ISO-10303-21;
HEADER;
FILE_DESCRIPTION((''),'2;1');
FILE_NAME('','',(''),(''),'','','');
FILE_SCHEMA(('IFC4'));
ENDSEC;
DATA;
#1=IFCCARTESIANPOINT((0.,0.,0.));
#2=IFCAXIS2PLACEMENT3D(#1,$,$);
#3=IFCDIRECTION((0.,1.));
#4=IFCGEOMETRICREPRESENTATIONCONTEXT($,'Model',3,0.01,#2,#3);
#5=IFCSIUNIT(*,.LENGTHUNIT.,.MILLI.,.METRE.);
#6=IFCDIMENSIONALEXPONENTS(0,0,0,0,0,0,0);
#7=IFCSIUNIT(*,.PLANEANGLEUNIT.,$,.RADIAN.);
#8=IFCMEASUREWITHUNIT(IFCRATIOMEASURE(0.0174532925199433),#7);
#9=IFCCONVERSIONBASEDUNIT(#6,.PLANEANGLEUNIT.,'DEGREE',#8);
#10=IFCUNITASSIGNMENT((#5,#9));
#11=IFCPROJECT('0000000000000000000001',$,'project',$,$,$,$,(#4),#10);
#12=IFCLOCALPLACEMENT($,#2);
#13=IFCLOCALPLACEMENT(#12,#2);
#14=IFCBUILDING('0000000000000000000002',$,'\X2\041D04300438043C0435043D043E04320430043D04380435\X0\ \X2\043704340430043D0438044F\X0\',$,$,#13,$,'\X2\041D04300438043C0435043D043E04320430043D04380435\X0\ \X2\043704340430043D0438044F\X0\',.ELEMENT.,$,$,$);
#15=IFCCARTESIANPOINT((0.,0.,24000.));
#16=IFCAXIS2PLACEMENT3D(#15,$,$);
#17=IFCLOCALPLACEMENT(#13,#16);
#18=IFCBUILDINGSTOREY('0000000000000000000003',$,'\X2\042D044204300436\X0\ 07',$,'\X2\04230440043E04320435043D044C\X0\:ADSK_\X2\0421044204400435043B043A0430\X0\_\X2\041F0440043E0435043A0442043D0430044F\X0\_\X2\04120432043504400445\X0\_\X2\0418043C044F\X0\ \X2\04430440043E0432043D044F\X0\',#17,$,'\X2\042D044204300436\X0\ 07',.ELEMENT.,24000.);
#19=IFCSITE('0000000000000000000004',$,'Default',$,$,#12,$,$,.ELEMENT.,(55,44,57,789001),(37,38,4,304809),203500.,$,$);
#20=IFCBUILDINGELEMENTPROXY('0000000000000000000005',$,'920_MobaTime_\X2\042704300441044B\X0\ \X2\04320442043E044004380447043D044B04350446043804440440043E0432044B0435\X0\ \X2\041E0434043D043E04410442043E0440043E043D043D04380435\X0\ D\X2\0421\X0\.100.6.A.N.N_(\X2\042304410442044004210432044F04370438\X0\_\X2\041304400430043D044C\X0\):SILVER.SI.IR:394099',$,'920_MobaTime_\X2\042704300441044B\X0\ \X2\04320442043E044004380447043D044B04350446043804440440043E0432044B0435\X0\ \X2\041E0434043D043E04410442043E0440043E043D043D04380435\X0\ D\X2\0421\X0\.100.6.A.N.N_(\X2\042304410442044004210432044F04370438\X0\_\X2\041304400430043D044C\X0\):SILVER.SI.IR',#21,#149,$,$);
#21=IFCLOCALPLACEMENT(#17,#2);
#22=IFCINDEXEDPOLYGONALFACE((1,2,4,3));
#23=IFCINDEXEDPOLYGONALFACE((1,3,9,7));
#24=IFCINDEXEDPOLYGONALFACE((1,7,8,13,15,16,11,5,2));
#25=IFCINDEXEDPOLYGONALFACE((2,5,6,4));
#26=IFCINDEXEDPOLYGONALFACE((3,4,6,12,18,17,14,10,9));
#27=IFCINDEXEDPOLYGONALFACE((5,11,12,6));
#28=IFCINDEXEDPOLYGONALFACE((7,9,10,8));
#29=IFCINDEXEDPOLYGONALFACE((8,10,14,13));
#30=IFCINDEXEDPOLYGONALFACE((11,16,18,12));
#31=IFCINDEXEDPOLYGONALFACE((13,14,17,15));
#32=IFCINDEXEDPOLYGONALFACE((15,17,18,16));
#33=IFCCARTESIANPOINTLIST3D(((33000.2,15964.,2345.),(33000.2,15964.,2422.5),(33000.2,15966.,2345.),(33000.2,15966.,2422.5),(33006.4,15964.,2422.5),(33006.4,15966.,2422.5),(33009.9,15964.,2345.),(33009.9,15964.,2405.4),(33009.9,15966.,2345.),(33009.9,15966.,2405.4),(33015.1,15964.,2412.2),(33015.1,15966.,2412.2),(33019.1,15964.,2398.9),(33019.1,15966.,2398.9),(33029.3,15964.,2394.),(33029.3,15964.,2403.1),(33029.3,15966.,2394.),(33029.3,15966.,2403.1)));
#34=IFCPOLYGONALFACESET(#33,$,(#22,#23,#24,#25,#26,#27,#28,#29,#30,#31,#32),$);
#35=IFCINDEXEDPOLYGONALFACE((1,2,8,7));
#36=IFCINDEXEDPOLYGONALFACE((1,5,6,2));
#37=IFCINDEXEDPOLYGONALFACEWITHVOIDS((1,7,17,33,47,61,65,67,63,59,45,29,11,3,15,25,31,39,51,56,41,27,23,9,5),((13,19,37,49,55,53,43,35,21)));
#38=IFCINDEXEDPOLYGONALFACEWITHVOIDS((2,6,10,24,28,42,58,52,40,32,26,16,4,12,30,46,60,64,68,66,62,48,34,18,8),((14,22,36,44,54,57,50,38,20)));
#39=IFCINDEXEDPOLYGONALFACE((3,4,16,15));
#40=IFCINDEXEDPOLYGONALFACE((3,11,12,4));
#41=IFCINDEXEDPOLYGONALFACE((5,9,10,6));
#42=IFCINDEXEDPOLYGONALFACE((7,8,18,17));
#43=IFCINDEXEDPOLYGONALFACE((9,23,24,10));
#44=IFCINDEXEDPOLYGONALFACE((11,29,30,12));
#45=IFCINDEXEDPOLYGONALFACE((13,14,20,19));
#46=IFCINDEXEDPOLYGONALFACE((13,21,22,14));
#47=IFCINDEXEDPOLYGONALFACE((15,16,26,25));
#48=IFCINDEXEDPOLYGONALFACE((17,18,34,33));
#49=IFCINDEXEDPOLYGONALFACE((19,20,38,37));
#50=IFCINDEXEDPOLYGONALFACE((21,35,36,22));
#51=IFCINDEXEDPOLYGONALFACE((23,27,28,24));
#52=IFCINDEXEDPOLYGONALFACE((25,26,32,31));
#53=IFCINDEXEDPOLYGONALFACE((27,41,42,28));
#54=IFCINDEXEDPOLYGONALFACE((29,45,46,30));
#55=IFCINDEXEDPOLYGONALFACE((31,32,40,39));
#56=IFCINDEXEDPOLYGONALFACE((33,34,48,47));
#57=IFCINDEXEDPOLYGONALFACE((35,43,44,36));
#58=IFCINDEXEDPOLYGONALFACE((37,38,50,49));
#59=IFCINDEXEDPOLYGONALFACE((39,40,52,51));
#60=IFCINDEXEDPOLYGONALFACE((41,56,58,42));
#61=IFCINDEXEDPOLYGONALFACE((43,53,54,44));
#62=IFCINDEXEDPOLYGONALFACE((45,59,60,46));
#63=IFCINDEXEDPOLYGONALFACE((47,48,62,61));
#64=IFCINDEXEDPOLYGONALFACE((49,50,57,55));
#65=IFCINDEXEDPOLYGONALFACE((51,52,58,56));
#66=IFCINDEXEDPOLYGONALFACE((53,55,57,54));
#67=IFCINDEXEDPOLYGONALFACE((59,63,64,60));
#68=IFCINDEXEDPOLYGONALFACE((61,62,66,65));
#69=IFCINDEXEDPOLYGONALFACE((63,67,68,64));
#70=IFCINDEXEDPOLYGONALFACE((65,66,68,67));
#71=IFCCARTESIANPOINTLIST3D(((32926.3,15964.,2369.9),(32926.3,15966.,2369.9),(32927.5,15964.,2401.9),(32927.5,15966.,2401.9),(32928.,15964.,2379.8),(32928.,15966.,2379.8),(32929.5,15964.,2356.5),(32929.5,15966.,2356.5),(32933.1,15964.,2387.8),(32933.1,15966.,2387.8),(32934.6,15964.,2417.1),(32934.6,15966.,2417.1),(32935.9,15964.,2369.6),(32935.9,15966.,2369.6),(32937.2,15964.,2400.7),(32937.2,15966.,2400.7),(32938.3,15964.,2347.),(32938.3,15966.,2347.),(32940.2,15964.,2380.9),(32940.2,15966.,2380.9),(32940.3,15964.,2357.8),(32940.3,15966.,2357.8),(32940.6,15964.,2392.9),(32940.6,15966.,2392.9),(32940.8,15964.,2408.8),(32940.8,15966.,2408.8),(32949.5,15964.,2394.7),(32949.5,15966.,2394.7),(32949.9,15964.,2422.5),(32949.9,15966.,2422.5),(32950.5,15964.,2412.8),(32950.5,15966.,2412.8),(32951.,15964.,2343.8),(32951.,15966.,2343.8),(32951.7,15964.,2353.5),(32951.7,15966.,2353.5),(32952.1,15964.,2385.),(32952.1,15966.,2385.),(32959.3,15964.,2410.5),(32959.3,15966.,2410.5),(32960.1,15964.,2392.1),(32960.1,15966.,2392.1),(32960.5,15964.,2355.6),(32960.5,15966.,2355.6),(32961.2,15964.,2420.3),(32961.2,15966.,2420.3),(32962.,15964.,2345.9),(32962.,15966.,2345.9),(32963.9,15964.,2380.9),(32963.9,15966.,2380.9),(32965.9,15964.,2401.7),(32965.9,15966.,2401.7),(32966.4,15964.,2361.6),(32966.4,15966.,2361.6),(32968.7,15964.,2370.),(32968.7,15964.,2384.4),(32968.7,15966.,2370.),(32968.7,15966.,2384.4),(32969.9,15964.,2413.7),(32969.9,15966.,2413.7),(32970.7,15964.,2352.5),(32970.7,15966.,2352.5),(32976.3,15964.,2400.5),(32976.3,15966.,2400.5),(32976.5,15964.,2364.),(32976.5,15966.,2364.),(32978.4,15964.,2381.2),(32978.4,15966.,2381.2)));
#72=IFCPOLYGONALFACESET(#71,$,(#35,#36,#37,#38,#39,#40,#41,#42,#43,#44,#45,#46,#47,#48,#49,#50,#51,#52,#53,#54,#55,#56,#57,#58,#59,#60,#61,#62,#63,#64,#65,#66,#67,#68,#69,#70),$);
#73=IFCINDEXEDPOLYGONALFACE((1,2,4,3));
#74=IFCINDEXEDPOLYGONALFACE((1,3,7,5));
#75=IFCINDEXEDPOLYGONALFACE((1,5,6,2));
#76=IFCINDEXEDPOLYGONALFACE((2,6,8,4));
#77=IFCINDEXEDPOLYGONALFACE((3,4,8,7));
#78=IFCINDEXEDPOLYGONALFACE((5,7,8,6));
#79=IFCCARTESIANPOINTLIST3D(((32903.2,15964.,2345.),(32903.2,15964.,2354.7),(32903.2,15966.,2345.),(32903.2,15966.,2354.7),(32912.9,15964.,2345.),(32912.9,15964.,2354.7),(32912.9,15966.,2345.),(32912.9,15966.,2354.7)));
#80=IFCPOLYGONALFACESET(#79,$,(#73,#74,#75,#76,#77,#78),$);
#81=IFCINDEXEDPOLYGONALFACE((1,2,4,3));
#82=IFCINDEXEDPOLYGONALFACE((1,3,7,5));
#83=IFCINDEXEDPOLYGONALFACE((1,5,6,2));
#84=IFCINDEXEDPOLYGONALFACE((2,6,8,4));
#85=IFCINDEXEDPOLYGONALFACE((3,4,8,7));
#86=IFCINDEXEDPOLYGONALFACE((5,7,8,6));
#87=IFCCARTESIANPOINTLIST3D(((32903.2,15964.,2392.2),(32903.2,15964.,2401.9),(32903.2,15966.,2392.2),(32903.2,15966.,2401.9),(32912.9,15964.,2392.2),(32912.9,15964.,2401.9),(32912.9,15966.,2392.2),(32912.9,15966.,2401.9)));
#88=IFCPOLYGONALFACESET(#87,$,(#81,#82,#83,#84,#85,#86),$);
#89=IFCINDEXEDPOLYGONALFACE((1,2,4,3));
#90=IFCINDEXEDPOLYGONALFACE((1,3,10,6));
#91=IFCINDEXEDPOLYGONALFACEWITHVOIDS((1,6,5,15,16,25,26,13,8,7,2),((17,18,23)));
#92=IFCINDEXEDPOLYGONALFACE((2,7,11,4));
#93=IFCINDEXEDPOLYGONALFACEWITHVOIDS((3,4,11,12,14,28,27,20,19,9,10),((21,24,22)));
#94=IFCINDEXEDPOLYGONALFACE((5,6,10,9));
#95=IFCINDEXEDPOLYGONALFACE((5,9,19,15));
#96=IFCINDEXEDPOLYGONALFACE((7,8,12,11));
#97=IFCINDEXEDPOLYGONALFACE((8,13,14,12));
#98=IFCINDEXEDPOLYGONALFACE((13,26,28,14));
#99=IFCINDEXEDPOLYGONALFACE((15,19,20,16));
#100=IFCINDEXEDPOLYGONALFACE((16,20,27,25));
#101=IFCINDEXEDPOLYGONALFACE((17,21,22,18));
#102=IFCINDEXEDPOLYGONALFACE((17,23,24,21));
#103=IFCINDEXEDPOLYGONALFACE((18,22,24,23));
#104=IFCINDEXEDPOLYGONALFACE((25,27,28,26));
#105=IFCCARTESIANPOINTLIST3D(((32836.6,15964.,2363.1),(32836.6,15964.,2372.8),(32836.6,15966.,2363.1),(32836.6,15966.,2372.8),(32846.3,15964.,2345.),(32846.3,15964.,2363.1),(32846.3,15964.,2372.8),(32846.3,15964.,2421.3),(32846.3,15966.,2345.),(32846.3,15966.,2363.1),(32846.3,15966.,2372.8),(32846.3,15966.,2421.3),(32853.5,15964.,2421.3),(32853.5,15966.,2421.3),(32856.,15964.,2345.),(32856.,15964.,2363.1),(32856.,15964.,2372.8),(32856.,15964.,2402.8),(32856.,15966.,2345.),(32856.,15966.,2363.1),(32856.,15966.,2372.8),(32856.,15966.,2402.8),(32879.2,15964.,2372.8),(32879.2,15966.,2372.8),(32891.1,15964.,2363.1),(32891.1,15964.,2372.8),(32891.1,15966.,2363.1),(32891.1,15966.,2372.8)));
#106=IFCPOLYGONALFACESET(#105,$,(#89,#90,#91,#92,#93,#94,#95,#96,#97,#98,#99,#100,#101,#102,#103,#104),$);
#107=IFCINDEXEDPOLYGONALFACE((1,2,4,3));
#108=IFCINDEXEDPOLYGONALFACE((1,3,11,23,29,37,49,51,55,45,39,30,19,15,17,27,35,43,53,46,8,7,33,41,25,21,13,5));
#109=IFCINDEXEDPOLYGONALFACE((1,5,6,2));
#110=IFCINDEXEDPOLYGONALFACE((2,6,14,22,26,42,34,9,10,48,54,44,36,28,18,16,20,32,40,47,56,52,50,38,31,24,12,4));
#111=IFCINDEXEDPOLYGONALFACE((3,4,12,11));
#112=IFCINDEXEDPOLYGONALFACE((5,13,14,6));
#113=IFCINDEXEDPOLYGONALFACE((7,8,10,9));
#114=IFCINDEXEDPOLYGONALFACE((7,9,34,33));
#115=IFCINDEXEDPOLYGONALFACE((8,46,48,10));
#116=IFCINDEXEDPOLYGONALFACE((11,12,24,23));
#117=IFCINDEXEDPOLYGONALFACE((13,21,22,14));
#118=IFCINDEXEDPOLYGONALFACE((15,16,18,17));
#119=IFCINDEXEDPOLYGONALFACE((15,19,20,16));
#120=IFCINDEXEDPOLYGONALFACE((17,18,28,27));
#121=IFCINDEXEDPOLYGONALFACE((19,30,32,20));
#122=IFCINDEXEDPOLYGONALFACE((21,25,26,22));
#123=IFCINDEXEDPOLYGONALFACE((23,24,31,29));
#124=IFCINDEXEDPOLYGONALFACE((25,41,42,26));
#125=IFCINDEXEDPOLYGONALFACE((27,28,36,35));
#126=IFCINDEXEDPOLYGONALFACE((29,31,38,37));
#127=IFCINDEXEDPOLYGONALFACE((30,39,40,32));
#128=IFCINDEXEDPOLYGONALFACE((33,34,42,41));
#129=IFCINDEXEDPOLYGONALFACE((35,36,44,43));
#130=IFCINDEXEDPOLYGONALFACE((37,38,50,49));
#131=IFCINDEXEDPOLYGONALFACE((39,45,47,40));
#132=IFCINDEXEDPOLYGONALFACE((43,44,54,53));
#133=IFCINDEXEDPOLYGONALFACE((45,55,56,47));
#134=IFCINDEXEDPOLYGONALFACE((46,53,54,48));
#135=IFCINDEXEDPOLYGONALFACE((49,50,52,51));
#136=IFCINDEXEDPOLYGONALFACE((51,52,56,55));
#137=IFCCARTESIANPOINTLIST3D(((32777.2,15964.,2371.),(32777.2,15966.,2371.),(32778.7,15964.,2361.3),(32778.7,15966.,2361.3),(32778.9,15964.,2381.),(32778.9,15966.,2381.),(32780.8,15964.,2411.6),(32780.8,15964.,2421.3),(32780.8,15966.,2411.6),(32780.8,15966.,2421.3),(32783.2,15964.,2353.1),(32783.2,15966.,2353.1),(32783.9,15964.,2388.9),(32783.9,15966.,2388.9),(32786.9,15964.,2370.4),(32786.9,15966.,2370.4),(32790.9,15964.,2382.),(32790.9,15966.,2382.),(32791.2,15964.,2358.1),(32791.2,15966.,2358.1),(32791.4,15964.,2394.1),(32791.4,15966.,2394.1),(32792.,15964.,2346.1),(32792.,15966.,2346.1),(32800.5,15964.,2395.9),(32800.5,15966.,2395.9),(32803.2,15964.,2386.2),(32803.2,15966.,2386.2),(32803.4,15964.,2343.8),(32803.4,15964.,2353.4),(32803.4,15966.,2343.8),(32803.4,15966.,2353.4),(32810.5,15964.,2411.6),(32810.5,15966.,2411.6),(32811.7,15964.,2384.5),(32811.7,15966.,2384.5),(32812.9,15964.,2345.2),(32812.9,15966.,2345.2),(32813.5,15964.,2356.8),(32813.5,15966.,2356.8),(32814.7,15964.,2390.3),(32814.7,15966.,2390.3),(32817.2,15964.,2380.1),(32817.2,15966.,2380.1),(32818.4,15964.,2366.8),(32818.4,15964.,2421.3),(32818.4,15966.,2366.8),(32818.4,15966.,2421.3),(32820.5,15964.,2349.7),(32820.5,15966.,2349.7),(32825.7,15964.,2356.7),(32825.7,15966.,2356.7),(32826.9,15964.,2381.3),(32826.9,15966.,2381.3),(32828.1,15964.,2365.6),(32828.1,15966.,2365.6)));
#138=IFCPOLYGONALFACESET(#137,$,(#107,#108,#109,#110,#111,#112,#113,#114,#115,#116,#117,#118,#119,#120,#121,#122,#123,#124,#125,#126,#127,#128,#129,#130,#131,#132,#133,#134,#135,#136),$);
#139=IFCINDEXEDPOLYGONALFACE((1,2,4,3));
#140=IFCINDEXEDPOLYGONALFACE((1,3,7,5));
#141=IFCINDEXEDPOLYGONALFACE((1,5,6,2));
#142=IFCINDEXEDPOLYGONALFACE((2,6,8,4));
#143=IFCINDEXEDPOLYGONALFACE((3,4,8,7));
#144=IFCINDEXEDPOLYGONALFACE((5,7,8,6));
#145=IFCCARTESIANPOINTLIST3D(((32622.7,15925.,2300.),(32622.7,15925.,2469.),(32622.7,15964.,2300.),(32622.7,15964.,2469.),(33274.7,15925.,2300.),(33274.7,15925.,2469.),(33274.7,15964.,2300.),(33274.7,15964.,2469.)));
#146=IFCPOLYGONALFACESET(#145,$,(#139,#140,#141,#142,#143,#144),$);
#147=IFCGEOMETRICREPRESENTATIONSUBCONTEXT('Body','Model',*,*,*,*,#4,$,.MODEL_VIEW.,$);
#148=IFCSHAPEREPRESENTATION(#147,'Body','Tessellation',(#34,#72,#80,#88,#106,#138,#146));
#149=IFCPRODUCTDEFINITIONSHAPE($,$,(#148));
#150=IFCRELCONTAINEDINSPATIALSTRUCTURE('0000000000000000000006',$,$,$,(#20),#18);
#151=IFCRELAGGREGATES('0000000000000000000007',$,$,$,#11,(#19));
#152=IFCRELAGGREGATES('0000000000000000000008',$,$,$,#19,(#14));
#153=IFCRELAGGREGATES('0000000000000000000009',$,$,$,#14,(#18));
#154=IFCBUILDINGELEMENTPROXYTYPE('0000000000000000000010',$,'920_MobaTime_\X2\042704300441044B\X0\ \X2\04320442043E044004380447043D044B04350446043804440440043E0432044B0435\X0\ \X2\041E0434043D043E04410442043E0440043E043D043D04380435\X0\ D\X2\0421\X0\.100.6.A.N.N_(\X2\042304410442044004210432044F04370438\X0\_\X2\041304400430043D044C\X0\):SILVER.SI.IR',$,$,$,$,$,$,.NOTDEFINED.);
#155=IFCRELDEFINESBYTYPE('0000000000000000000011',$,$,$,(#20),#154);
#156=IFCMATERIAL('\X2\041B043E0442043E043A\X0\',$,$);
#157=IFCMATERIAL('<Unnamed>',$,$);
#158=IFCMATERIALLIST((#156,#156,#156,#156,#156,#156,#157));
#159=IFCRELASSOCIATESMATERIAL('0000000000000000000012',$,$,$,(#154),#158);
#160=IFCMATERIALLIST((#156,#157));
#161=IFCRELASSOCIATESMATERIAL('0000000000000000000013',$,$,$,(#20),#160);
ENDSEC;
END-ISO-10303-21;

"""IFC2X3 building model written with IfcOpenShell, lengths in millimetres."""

from ifc_helpers import new_model, entity, si_unit, converted_unit, direction, frame, origin, origin_2d_with_axis, place, context, subcontext, project, spatial, polyline, rectangle, outline, extrude, source, transform, mapped, material, material_list, type_object, type_shapes, element, save


model = new_model("IFC2X3")

# Units and contexts
model_context = context("Model", 3, precision=0.01, world=origin(), true_north=direction((0.0, 1.0)))
body_context = subcontext(model_context, "Body", "Model", "MODEL_VIEW")
ifc_project = project(units=[si_unit("LENGTHUNIT", "METRE", prefix="MILLI"), converted_unit("PLANEANGLEUNIT", "DEGREE", entity("IfcRatioMeasure", 0.0174532925199433), si_unit("PLANEANGLEUNIT", "RADIAN"), dimensions=[0, 0, 0, 0, 0, 0, 0])], contexts=[model_context])

# Site, building, storey
site_placement = place(None, origin())
site = spatial("IfcSite", under=ifc_project, at=site_placement, Name="Default", CompositionType="ELEMENT", RefLatitude=(55, 44, 57, 789001), RefLongitude=(37, 38, 4, 304809), RefElevation=203500.0)
building_placement = place(site_placement, origin())
building = spatial("IfcBuilding", under=site, at=building_placement, Name="Наименование здания", LongName="Наименование здания", CompositionType="ELEMENT")
storey_placement = place(building_placement, frame((0.0, 0.0, 24000.0)))
storey = spatial("IfcBuildingStorey", under=building, at=storey_placement, Name="Этаж 07", ObjectType="Уровень:ADSK_Стрелка_Проектная_Вверх_Имя уровня", LongName="Этаж 07", CompositionType="ELEMENT", Elevation=24000.0)

# Building element proxy
ifc_material_1 = material(Name="Лоток")
ifc_material_2 = material(Name="<Unnamed>")
ifc_material_list_1 = material_list([ifc_material_1, ifc_material_2])
ifc_material_list_2 = material_list([ifc_material_1, ifc_material_1, ifc_material_1, ifc_material_1, ifc_material_1, ifc_material_1, ifc_material_2])
building_element_proxy_type = type_object("IfcBuildingElementProxyType", Name="920_MobaTime_Часы вторичныецифровые Односторонние DС.100.6.A.N.N_(УстрСвязи_Грань):SILVER.SI.IR", PredefinedType="NOTDEFINED", material=ifc_material_list_2)
shared_shape = source(origin(), body_context, "Body", "SweptSolid", [
    extrude(outline(polyline([(-49.3, -13.1), (28.2, -13.1), (28.2, -6.8), (17.9, 1.8), (8.8, 16.0), (-0.3, 16.0), (4.6, 5.8), (11.1, -3.4), (-49.3, -3.4), (-49.3, -13.1)])), frame((-64.6, 9.8, 39.0), z_axis=(0.0, 0.0, 1.0), x_axis=(0.0, 1.0, 0.0)), (0.0, 0.0, 1.0), 2.0),
    extrude(outline(polyline([(2.2, -27.6), (19.0, -27.6), (30.5, -16.1), (33.3, -4.9), (31.0, 5.8), (21.8, 17.2), (5.2, 27.3), (-11.1, 33.0), (-24.0, 32.7), (-33.6, 27.6), (-40.3, 18.6), (-42.8, 5.7), (-38.0, -6.3), (-27.2, -14.9), (-17.5, -17.7), (-8.2, -16.4), (-0.3, -11.9), (5.1, -4.5), (7.3, 6.2), (4.0, 17.2), (18.4, 7.3), (23.6, -2.4), (22.0, -11.4), (14.2, -18.4), (5.3, -18.3), (2.2, -27.6)]), holes=[polyline([(-9.0, 23.3), (-1.3, 14.3), (-2.5, 2.0), (-11.4, -7.0), (-23.4, -6.0), (-32.2, 2.9), (-31.2, 15.1), (-25.6, 22.1), (-17.5, 24.9), (-9.0, 23.3)])]), frame((-2.7, 3.6, 39.0), z_axis=(0.0, 0.0, 1.0), x_axis=(-0.427649, 0.903945, 0.0)), (0.0, 0.0, 1.0), 2.0),
    extrude(rectangle(XDim=9.7, YDim=9.7, at=origin_2d_with_axis()), frame((40.6, -34.7, 39.0)), (0.0, 0.0, 1.0), 2.0),
    extrude(rectangle(XDim=9.7, YDim=9.7, at=origin_2d_with_axis()), frame((40.6, 12.6, 39.0)), (0.0, 0.0, 1.0), 2.0),
    extrude(outline(polyline([(-0.9, -28.1), (8.8, -28.1), (8.8, -9.9), (18.5, -9.9), (18.5, -0.2), (8.8, -0.2), (8.8, 48.3), (1.5, 48.3), (-36.0, -0.2), (-36.0, -9.9), (-0.9, -9.9), (-0.9, -28.1)]), holes=[polyline([(-0.9, -0.2), (-24.1, -0.2), (-0.9, 29.7), (-0.9, -0.2)])]), frame((93.6, -11.4, 39.0)), (0.0, 0.0, 1.0), 2.0),
    extrude(outline(polyline([(3.3, -28.3), (12.5, -28.3), (20.5, -25.0), (26.8, -18.9), (30.7, -10.0), (31.4, 1.6), (26.9, 11.8), (20.1, 18.4), (11.1, 22.3), (1.0, 23.3), (-7.9, 20.4), (-14.9, 14.5), (-18.9, 6.2), (-17.1, -9.0), (-36.7, 0.5), (-29.1, 29.2), (-38.5, 31.7), (-48.1, -4.6), (-11.6, -23.1), (-8.0, -14.0), (-10.8, -7.6), (-10.2, 1.1), (-3.0, 11.8), (9.2, 12.8), (20.0, 5.5), (21.4, -7.5), (15.5, -16.4), (4.6, -18.6), (3.3, -28.3)])), frame((147.1, -8.5, 39.0), z_axis=(0.0, 0.0, 1.0), x_axis=(0.256974, -0.966418, 0.0)), (0.0, 0.0, 1.0), 2.0),
    extrude(rectangle(XDim=652.0, YDim=169.0, at=origin_2d_with_axis()), frame((0.0, 0.0, 0.0), z_axis=(0.0, 0.0, 1.0), x_axis=(-1.0, 0.0, 0.0)), (0.0, 0.0, 1.0), 39.0),
])
type_shapes(building_element_proxy_type, [shared_shape])
for number, where, z_axis, x_axis, name in (
    (1, (32948.7, 15925.0, 2384.5), (0.0, 1.0, 0.0), (-1.0, 0.0, 0.0), "920_MobaTime_Часы вторичныецифровые Односторонние DС.100.6.A.N.N_(УстрСвязи_Грань):SILVER.SI.IR:394099"),
):
    element("IfcBuildingElementProxy", number, at=place(storey_placement, frame(where, z_axis=z_axis, x_axis=x_axis)), inside=storey, type_object=building_element_proxy_type, material=ifc_material_list_1, Name=name, ObjectType="920_MobaTime_Часы вторичныецифровые Односторонние DС.100.6.A.N.N_(УстрСвязи_Грань):SILVER.SI.IR", context=body_context, shape_type="MappedRepresentation", body=[
        mapped(shared_shape, transform((0.0, 0.0, 0.0), scale=1.0)),
    ])

save(model, "model.ifc")
